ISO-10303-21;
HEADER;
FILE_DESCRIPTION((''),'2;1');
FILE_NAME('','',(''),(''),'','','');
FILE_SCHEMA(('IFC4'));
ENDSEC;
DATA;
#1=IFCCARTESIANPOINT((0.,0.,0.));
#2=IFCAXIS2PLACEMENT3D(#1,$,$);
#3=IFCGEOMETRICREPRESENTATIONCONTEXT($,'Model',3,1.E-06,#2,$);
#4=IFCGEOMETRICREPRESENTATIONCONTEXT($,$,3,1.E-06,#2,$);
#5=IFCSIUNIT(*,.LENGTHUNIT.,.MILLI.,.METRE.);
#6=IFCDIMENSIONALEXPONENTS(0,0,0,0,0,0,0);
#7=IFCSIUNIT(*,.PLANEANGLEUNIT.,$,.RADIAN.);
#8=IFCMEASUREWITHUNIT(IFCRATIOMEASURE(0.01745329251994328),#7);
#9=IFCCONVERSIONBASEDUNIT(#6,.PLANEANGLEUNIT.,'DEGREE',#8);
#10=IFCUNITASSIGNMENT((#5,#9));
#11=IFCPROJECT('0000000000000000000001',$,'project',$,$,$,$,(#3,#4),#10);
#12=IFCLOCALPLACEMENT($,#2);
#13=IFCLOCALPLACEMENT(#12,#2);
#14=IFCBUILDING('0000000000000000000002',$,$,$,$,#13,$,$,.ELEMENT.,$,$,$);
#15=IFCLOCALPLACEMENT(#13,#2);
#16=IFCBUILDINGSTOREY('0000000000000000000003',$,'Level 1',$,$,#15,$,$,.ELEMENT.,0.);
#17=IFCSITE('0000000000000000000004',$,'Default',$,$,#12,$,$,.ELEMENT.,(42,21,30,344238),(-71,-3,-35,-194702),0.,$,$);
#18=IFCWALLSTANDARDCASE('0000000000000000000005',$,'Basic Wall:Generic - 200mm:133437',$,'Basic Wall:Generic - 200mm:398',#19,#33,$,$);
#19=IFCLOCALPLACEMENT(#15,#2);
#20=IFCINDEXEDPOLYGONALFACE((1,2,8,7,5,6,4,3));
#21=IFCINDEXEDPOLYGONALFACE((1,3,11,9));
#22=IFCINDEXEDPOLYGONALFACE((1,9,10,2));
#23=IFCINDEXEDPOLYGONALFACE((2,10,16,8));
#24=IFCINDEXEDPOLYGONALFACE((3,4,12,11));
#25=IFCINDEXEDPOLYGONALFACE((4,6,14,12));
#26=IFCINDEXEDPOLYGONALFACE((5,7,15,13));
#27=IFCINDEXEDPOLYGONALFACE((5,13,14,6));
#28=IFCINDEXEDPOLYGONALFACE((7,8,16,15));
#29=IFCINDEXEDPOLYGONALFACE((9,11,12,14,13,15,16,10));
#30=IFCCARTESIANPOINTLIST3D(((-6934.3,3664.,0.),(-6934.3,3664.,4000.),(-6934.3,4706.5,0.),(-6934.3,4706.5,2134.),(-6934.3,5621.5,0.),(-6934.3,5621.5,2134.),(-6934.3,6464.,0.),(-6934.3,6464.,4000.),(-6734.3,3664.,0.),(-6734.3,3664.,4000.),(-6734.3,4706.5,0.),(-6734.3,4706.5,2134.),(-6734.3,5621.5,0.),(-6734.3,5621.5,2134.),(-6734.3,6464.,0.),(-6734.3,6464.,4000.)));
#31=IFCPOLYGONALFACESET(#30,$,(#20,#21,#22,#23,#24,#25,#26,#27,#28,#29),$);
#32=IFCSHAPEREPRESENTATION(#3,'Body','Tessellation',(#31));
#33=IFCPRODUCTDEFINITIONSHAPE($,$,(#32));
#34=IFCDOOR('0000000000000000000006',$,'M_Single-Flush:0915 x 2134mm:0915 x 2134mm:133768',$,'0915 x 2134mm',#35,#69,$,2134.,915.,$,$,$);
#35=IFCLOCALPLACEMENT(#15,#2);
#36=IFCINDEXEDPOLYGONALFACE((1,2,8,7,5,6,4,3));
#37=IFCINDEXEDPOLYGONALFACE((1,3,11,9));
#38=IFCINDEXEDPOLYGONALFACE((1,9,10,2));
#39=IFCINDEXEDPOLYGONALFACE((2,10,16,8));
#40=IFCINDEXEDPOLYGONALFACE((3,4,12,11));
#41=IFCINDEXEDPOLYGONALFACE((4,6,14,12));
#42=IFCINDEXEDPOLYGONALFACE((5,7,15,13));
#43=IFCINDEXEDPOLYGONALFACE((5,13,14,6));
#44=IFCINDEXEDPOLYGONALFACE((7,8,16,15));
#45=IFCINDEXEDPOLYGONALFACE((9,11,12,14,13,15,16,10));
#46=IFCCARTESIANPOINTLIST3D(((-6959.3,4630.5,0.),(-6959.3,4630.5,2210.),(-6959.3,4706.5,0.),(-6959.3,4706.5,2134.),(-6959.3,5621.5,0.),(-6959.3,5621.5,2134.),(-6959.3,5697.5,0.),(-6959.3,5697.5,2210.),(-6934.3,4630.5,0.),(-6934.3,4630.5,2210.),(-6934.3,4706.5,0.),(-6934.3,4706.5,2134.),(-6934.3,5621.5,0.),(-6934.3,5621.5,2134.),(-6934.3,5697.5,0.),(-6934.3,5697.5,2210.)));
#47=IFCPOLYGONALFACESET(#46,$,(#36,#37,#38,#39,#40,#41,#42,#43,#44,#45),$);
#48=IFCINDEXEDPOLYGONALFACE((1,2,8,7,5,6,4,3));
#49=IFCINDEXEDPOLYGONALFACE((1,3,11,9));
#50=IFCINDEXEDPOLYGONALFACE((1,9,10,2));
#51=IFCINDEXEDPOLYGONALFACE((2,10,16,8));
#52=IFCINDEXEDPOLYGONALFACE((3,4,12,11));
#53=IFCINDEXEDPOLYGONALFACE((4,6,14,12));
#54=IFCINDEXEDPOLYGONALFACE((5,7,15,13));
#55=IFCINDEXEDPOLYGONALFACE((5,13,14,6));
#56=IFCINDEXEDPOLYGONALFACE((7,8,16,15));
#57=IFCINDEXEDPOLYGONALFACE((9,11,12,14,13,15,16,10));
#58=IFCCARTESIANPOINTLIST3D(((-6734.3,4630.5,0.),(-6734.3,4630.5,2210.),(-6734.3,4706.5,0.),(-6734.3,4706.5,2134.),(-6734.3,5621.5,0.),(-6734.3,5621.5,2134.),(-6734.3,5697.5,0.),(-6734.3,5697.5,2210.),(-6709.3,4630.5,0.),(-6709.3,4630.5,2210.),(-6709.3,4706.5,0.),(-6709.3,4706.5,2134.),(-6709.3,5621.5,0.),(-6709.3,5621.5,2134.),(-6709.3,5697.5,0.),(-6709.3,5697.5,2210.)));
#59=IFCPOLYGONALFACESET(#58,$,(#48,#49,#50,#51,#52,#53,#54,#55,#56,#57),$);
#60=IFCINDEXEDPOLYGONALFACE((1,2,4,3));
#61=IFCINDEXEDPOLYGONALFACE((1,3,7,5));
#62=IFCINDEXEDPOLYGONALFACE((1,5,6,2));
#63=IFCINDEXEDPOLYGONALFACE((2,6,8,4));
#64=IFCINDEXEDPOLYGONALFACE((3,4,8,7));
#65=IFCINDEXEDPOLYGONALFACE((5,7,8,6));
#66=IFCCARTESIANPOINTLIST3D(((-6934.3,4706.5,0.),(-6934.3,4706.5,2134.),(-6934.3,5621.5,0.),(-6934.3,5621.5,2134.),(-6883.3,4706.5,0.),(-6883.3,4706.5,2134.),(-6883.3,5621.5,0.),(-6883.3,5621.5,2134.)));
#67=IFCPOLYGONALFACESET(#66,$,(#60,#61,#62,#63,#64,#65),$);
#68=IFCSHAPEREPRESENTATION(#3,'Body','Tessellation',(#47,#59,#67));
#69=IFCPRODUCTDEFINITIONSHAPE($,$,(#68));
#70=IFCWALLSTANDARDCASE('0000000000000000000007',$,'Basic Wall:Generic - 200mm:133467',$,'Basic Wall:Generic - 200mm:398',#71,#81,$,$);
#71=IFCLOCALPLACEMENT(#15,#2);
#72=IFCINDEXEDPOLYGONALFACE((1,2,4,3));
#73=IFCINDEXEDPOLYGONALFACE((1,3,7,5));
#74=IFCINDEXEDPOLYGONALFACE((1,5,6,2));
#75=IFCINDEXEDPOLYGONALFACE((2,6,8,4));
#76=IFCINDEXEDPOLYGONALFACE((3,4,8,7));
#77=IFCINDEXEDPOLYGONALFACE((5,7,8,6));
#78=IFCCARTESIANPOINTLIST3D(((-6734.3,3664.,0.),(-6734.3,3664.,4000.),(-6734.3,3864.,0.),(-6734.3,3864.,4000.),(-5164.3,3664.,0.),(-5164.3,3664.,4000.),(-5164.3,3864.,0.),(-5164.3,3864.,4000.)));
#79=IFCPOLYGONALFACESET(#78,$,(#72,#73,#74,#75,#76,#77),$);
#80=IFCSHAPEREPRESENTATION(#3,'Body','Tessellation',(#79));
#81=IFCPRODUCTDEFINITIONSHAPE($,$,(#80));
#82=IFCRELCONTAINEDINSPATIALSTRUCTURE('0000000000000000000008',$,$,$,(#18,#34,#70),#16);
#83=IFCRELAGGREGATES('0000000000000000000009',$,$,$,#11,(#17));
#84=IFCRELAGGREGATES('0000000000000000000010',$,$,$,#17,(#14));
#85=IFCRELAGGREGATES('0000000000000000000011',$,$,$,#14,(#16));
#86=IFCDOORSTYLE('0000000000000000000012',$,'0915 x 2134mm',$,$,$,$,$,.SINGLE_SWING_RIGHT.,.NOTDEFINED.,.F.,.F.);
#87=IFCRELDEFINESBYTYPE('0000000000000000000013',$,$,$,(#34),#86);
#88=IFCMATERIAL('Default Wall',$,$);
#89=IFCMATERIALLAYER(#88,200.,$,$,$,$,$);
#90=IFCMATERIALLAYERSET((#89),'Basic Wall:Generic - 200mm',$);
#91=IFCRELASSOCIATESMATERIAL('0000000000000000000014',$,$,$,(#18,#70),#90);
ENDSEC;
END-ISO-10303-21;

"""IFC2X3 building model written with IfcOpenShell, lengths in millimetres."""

from ifc_helpers import new_model, entity, si_unit, converted_unit, frame, frame_2d, origin, origin_2d_with_axis, place, context, project, spatial, polyline, rectangle, outline, extrude, source, transform, mapped, material, layer, layer_set, layer_usage, type_object, type_shapes, element, fill, save


model = new_model("IFC2X3")

# Units and contexts
model_context = context("Model", 3, precision=1e-06, world=origin())
context_of_model = context(None, 3, precision=1e-06, world=origin())
ifc_project = project(units=[si_unit("LENGTHUNIT", "METRE", prefix="MILLI"), converted_unit("PLANEANGLEUNIT", "DEGREE", entity("IfcRatioMeasure", 0.01745329251994328), si_unit("PLANEANGLEUNIT", "RADIAN"), dimensions=[0, 0, 0, 0, 0, 0, 0])], contexts=[model_context, context_of_model])

# Site, building, storey
site_placement = place(None, origin())
site = spatial("IfcSite", under=ifc_project, at=site_placement, Name="Default", CompositionType="ELEMENT", RefLatitude=(42, 21, 30, 344238), RefLongitude=(-71, -3, -35, -194702), RefElevation=0.0)
building_placement = place(site_placement, origin())
building = spatial("IfcBuilding", under=site, at=building_placement, CompositionType="ELEMENT")
storey_placement = place(building_placement, origin())
storey = spatial("IfcBuildingStorey", under=building, at=storey_placement, Name="Level 1", CompositionType="ELEMENT", Elevation=0.0)

# Shared definitions
ifc_material_1 = material(Name="Default Wall")
ifc_layer_1 = layer(ifc_material_1, 200.0)
ifc_layer_set_1 = layer_set([ifc_layer_1], Name="Basic Wall:Generic - 200mm")
door_style = type_object("IfcDoorStyle", Name="0915 x 2134mm", ConstructionType="NOTDEFINED", OperationType="SINGLE_SWING_RIGHT", ParameterTakesPrecedence=False, Sizeable=False)
shared_shape_1 = source(origin(), model_context, "Body", "SweptSolid", [
    extrude(outline(polyline([(-533.5, -1124.0), (533.5, -1124.0), (533.5, 1086.0), (457.5, 1086.0), (457.5, -1048.0), (-457.5, -1048.0), (-457.5, 1086.0), (-533.5, 1086.0), (-533.5, -1124.0)])), frame((457.5, 200.0, 1086.0), z_axis=(0.0, 1.0, 0.0), x_axis=(1.0, 0.0, 0.0)), (0.0, 0.0, 1.0), 25.0),
    extrude(outline(polyline([(-1124.0, -533.5), (1086.0, -533.5), (1086.0, -457.5), (-1048.0, -457.5), (-1048.0, 457.5), (1086.0, 457.5), (1086.0, 533.5), (-1124.0, 533.5), (-1124.0, -533.5)])), frame((457.5, -25.0, 1086.0), z_axis=(0.0, 1.0, 0.0), x_axis=(0.0, 0.0, -1.0)), (0.0, 0.0, 1.0), 25.0),
    extrude(rectangle(XDim=51.0, YDim=915.0, at=origin_2d_with_axis()), frame((457.5, 174.5, 0.0), z_axis=(0.0, 0.0, 1.0), x_axis=(0.0, 1.0, 0.0)), (0.0, 0.0, 1.0), 2134.0),
])
type_shapes(door_style, [shared_shape_1])

# Wall, opening, door
ifc_layer_usage_1 = layer_usage(ifc_layer_set_1, "AXIS2", "NEGATIVE", 100.0)
wall_1_placement = place(storey_placement, frame((-6834.3, 6464.0, 0.0), z_axis=(0.0, 0.0, 1.0), x_axis=(0.0, -1.0, 0.0)))
wall_1 = element("IfcWallStandardCase", 1, at=wall_1_placement, inside=storey, material=ifc_layer_usage_1, Name="Basic Wall:Generic - 200mm:133437", ObjectType="Basic Wall:Generic - 200mm:398", context=model_context, shape_type="SweptSolid", body=[
    extrude(rectangle(XDim=2800.0, YDim=200.0, at=frame_2d((1400.0, 0.0), x_axis=(-1.0, 0.0))), origin(), (0.0, 0.0, 1.0), 4000.0),
])
opening_1_placement = place(wall_1_placement, frame((1757.5, 100.0, 0.0)))
opening_1 = element("IfcOpeningElement", 2, at=opening_1_placement, cuts=wall_1, ObjectType="Opening", context=model_context, shape_type="SweptSolid", body=[
    extrude(rectangle(XDim=915.0, YDim=2134.0, at=frame_2d((1067.0, 457.5), x_axis=(0.0, 1.0))), frame((0.0, 0.0, 0.0), z_axis=(0.0, -1.0, 0.0), x_axis=(0.0, 0.0, 1.0)), (0.0, 0.0, 1.0), 200.0),
])
door_1_placement = place(opening_1_placement, frame((0.0, 0.0, 0.0), z_axis=(0.0, 0.0, 1.0), x_axis=(-1.0, 0.0, 0.0)))
door_1 = element("IfcDoor", 3, at=door_1_placement, inside=storey, type_object=door_style, Name="M_Single-Flush:0915 x 2134mm:0915 x 2134mm:133768", ObjectType="0915 x 2134mm", OverallHeight=2134.0, OverallWidth=915.0, context=model_context, shape_type="MappedRepresentation", body=[
    mapped(shared_shape_1, transform((0.0, 0.0, 0.0), scale=1.0)),
])
fill(opening_1, door_1)

# Wall
ifc_layer_usage_2 = layer_usage(ifc_layer_set_1, "AXIS2", "NEGATIVE", 100.0)
wall_2_placement = place(storey_placement, frame((-6734.3, 3764.0, 0.0)))
element("IfcWallStandardCase", 4, at=wall_2_placement, inside=storey, material=ifc_layer_usage_2, Name="Basic Wall:Generic - 200mm:133467", ObjectType="Basic Wall:Generic - 200mm:398", context=model_context, shape_type="SweptSolid", body=[
    extrude(rectangle(XDim=1570.0, YDim=200.0, at=frame_2d((785.0, 0.0), x_axis=(-1.0, 0.0))), origin(), (0.0, 0.0, 1.0), 4000.0),
])

save(model, "model.ifc")
